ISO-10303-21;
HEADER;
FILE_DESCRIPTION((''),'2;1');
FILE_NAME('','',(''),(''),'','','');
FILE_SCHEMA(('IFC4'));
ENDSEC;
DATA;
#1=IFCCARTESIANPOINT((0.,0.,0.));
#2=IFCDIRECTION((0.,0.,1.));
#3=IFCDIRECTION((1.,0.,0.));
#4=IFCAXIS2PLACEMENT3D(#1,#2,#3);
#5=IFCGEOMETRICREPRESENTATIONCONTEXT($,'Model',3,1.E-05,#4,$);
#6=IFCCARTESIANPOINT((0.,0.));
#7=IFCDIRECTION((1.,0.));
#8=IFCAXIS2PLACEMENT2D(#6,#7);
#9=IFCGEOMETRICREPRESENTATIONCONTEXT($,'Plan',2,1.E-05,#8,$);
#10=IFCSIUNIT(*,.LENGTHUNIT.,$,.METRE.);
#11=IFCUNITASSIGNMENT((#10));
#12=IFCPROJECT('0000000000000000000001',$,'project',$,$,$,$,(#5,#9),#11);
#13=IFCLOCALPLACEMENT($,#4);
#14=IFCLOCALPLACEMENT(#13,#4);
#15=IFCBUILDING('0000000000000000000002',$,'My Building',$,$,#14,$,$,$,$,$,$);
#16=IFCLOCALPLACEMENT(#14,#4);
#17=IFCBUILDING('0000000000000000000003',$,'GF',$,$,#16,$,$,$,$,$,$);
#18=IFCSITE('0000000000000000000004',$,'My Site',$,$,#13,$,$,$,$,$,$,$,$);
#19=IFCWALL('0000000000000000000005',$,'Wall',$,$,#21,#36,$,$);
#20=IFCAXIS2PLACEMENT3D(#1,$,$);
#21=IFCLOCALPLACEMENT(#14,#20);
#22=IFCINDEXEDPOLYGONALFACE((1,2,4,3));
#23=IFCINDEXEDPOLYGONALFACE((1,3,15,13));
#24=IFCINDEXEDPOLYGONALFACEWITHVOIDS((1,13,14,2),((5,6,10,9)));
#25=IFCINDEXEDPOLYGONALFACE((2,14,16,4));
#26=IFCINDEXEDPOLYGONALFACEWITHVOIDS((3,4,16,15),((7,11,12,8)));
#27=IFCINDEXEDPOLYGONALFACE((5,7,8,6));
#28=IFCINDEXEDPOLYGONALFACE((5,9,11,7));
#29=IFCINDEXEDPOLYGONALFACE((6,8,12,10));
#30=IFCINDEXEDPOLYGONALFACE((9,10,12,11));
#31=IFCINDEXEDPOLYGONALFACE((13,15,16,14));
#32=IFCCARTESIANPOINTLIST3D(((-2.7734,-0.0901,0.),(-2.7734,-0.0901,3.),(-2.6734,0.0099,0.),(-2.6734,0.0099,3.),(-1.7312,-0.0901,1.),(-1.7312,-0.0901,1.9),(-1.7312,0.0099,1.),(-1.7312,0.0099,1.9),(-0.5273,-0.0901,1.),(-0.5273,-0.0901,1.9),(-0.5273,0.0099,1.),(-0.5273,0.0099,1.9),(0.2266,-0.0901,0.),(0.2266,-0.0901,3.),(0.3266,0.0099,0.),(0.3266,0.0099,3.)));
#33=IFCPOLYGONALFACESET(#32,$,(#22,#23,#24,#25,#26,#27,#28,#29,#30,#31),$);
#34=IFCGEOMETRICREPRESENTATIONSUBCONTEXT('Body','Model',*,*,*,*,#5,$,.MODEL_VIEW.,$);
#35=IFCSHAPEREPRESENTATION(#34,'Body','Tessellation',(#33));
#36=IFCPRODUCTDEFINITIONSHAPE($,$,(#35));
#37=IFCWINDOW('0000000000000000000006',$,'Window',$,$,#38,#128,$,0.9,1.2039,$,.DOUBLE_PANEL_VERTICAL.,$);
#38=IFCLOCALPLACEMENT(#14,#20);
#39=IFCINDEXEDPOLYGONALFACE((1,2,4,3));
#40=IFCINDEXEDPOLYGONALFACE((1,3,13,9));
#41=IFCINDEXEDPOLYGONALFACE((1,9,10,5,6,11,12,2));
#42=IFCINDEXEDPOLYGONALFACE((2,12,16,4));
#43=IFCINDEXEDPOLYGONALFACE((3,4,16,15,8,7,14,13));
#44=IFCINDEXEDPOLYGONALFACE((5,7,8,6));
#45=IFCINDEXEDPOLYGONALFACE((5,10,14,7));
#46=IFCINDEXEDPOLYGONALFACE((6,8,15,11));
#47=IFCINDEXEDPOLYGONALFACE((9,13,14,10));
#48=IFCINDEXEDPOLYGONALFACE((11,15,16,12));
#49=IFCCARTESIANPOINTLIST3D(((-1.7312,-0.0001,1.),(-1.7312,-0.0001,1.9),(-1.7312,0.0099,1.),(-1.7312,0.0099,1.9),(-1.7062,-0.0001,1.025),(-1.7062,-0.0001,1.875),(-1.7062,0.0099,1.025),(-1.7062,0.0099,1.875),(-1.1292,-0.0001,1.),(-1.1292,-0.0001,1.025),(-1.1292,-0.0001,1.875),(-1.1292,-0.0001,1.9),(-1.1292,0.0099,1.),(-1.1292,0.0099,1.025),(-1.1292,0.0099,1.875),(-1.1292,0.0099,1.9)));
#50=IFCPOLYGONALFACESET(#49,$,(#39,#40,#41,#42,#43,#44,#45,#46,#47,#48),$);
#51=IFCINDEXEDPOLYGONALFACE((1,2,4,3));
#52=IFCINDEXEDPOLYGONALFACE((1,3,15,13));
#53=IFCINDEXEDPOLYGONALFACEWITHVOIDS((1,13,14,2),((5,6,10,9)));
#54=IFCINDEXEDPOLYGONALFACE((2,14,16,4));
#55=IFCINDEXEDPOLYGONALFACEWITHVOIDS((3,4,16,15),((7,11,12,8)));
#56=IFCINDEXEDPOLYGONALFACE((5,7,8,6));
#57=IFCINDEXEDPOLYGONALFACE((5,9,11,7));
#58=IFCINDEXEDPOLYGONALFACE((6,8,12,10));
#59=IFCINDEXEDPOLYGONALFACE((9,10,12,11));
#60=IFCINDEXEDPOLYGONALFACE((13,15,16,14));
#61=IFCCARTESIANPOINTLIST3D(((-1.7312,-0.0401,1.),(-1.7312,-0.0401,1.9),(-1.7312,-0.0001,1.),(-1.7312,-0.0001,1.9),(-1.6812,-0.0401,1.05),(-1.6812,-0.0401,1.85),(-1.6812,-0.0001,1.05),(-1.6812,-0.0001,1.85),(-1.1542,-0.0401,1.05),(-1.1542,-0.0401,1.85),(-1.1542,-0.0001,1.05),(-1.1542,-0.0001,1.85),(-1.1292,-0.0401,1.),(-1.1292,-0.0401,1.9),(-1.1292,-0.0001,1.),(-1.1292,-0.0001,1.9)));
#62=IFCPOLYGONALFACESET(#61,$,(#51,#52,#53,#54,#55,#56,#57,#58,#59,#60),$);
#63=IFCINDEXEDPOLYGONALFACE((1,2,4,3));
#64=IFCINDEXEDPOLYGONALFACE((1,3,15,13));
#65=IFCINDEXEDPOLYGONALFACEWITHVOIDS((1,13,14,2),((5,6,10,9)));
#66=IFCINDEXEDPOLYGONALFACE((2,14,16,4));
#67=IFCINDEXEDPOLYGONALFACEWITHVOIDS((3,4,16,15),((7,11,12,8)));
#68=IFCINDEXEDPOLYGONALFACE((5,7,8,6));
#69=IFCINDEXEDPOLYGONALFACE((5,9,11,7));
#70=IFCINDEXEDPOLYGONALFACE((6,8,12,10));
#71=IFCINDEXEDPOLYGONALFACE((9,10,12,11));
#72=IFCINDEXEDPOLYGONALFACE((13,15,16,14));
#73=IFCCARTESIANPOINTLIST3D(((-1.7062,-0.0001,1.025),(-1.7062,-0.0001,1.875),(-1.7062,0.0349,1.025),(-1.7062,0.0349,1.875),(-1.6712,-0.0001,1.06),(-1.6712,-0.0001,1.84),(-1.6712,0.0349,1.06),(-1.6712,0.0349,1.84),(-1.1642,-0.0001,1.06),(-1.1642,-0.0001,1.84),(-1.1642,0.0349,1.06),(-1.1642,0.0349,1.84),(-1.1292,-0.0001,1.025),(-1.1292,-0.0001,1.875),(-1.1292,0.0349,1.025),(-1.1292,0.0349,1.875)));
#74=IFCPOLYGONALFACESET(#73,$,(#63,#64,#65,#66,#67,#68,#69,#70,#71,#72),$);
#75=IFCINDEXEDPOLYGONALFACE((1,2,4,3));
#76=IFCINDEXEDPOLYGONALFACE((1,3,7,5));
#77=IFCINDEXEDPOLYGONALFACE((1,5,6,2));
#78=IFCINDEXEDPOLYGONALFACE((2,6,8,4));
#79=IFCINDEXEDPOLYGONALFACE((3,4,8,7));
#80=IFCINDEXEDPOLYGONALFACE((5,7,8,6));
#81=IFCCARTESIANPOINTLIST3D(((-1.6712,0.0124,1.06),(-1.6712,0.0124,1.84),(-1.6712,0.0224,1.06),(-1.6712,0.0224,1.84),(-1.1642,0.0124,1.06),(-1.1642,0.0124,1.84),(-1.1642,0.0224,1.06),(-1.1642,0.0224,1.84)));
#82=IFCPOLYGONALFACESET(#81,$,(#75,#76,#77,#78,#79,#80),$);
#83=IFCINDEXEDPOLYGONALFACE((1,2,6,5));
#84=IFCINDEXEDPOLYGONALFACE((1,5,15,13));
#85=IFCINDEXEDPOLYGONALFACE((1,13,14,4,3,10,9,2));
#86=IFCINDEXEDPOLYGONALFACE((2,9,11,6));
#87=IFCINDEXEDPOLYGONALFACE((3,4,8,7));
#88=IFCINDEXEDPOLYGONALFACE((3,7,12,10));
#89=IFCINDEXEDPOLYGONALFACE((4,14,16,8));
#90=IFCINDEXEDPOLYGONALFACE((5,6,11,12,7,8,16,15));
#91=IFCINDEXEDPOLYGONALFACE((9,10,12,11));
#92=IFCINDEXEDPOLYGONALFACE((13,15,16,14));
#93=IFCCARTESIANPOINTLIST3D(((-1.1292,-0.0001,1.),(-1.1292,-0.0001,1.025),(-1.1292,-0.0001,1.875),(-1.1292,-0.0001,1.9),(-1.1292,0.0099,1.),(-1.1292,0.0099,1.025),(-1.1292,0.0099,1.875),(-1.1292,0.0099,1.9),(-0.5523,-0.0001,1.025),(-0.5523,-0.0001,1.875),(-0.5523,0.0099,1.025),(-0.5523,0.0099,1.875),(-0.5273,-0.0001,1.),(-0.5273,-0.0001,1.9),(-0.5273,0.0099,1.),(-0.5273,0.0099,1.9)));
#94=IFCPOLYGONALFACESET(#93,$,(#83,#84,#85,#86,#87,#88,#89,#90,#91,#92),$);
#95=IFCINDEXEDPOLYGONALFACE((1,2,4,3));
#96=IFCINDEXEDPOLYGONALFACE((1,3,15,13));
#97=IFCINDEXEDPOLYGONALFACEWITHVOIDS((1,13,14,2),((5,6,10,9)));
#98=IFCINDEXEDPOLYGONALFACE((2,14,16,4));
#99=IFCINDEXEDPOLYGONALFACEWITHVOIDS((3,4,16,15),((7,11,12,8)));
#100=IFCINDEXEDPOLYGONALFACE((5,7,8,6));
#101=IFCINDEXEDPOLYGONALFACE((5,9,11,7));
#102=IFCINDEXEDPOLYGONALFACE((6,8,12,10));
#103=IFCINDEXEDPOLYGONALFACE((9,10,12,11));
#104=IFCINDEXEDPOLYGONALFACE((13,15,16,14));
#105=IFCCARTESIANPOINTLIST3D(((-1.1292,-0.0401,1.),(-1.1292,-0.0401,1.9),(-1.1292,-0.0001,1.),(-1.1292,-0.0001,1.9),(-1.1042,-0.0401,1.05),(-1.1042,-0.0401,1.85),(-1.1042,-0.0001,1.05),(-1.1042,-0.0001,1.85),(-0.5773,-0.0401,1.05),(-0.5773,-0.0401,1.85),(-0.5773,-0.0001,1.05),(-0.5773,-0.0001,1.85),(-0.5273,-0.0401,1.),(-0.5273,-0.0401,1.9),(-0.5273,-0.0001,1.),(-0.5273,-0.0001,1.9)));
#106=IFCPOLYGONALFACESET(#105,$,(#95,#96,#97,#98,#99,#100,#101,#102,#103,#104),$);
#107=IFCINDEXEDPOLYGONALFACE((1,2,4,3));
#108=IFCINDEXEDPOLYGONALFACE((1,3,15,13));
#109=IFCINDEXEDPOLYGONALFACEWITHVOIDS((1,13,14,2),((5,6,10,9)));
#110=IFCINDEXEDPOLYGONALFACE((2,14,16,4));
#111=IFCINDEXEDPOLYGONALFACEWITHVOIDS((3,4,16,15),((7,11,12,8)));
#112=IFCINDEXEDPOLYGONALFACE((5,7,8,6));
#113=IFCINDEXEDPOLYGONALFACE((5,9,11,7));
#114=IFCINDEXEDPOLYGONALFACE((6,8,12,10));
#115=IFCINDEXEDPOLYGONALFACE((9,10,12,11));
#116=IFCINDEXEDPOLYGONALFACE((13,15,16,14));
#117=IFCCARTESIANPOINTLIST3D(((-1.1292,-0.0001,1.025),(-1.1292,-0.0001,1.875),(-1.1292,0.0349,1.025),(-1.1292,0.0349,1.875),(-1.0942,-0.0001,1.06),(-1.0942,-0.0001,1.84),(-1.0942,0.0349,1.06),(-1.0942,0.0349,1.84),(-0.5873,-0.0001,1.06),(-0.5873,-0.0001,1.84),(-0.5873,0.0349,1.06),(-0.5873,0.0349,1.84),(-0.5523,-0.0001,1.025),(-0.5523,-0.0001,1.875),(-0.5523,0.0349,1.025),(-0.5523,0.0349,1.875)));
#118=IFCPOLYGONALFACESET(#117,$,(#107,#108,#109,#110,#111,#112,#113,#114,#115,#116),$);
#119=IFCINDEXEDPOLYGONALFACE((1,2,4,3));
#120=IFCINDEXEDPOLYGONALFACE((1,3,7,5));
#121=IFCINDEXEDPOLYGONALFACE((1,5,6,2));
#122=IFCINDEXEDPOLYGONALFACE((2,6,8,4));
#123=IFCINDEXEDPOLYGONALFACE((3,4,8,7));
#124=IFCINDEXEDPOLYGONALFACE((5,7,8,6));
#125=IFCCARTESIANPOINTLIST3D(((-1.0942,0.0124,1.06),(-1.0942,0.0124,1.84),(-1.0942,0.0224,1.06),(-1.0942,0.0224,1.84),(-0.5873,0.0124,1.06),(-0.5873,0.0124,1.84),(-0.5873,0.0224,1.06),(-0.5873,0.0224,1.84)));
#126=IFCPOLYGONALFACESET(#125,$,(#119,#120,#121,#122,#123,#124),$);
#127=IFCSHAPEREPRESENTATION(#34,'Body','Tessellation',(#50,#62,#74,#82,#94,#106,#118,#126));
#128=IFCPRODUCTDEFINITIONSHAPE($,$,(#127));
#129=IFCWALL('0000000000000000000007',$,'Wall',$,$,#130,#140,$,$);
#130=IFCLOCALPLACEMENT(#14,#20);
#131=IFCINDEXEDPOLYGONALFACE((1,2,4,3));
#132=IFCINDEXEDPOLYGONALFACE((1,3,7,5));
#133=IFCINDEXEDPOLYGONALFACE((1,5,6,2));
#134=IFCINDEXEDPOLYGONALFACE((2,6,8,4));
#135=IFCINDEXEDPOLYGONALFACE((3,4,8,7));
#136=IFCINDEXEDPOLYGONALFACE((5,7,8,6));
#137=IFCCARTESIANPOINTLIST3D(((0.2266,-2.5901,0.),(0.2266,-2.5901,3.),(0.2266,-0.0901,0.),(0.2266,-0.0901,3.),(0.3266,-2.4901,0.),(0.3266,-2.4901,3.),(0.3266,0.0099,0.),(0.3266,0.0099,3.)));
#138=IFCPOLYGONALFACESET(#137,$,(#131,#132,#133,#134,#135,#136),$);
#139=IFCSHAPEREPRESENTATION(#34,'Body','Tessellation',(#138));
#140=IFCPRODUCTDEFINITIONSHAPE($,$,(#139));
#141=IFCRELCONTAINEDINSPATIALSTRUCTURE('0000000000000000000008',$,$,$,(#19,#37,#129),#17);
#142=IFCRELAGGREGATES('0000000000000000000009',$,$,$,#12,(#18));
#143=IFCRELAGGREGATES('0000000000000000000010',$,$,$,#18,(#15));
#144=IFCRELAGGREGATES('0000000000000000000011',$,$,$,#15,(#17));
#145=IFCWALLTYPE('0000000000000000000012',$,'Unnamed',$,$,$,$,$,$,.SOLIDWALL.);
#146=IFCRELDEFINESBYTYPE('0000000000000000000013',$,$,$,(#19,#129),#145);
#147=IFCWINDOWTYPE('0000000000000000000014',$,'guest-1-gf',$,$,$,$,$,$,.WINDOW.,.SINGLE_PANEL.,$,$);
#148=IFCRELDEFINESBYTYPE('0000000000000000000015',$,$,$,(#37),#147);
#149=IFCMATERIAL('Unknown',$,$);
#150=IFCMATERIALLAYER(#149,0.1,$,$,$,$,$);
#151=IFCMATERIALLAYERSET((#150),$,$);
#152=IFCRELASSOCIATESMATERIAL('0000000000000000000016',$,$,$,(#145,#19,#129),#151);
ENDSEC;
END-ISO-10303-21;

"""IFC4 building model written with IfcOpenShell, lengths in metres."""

from ifc_helpers import new_model, entity, si_unit, frame, origin_with_axes, origin_2d_with_axis, place, context, subcontext, project, spatial, line, indexed_curve, outline, extrude, shape, source, transform, mapped, material, layer, layer_set, layer_usage, type_object, type_shapes, element, fill, save


model = new_model("IFC4")

# Units and contexts
model_context = context("Model", 3, precision=1e-05, world=origin_with_axes())
plan_context = context("Plan", 2, precision=1e-05, world=origin_2d_with_axis())
body_context_1 = subcontext(model_context, "Body", "Model", "MODEL_VIEW")
body_context_2 = subcontext(plan_context, "Body", "Plan", "PLAN_VIEW")
ifc_project = project(units=[si_unit("LENGTHUNIT", "METRE")], contexts=[model_context, plan_context])

# Site, buildings
site_placement = place(None, origin_with_axes())
site = spatial("IfcSite", under=ifc_project, at=site_placement, Name="My Site")
building_1_placement = place(site_placement, origin_with_axes())
building_1 = spatial("IfcBuilding", under=site, at=building_1_placement, Name="My Building")
building_2_placement = place(building_1_placement, origin_with_axes())
building_2 = spatial("IfcBuilding", under=building_1, at=building_2_placement, Name="GF")

# Shared definitions
ifc_material = material(Name="Unknown")

# Shared definitions
ifc_layer_1 = layer(ifc_material, 0.1)
ifc_layer_set_1 = layer_set([ifc_layer_1])
wall_type = type_object("IfcWallType", Name="Unnamed", PredefinedType="SOLIDWALL", material=ifc_layer_set_1)

# Wall, opening, window
ifc_layer_usage_1 = layer_usage(ifc_layer_set_1, "AXIS2", "POSITIVE", 0.0)
wall_1_placement = place(building_2_placement, frame((-2.7734, -0.0901, 0.0), z_axis=(0.0, 0.0, 1.0), x_axis=(1.0, 0.0, 0.0)))
wall_1 = element("IfcWall", 1, at=wall_1_placement, inside=building_2, type_object=wall_type, material=ifc_layer_usage_1, Name="Wall", context=body_context_1, shape_type="SweptSolid", body=[
    extrude(outline(indexed_curve([(0.0, 0.0), (0.1, 0.1), (3.1, 0.1), (3.0, 0.0)], segments=[line(1, 2, 3, 4, 1)])), origin_with_axes(), (0.0, 0.0, 1.0), 3.0),
])
shared_shape_1 = source(origin_with_axes(), body_context_1, "Body", "SweptSolid", [
    extrude(outline(indexed_curve([(0.0, 0.0), (1.2039, 0.0), (1.2039, 0.9), (0.0, 0.9)], segments=[line(1, 2, 3, 4, 1)])), frame((0.0, -0.6, 0.0), z_axis=(0.0, -1.0, 0.0), x_axis=(1.0, 0.0, 0.0)), (0.0, 0.0, -1.0), 1.2),
])
opening_1_placement = place(wall_1_placement, frame((1.0422, 0.0, 1.0), z_axis=(0.0, 0.0, 1.0), x_axis=(1.0, 0.0, 0.0)))
opening_1 = element("IfcOpeningElement", 2, at=opening_1_placement, cuts=wall_1, PredefinedType="OPENING", context=body_context_1, shape_type="MappedRepresentation", body=[
    mapped(shared_shape_1, transform((0.0, 0.0, 0.0), x_axis=(1.0, 0.0, 0.0), y_axis=(0.0, 1.0, 0.0), z_axis=(0.0, 0.0, 1.0), scale=1.0)),
])
window_type_1 = type_object("IfcWindowType", Name="guest-1-gf", PartitioningType="SINGLE_PANEL", PredefinedType="WINDOW")
shared_shape_2 = source(origin_with_axes(), body_context_1, "Body", "SweptSolid", [
    extrude(outline(indexed_curve([(0.602, 0.0), (0.0, 0.0), (0.0, 0.9), (0.602, 0.9), (0.602, 0.875), (0.025, 0.875), (0.025, 0.025), (0.602, 0.025)], segments=[line(1, 2, 3, 4, 5, 6, 7, 8, 1)])), frame((0.0, 0.09, 0.0), z_axis=(0.0, -1.0, 0.0), x_axis=(1.0, 0.0, 0.0)), (0.0, 0.0, -1.0), 0.01),
    extrude(outline(indexed_curve([(0.0, 0.0), (0.602, 0.0), (0.602, 0.9), (0.0, 0.9)], segments=[line(1, 2, 3, 4, 1)]), holes=[indexed_curve([(0.05, 0.05), (0.577, 0.05), (0.577, 0.85), (0.05, 0.85)], segments=[line(1, 2, 3, 4, 1)])]), frame((0.0, 0.05, 0.0), z_axis=(0.0, -1.0, 0.0), x_axis=(1.0, 0.0, 0.0)), (0.0, 0.0, -1.0), 0.04),
    extrude(outline(indexed_curve([(0.0, 0.0), (0.577, 0.0), (0.577, 0.85), (0.0, 0.85)], segments=[line(1, 2, 3, 4, 1)]), holes=[indexed_curve([(0.035, 0.035), (0.542, 0.035), (0.542, 0.815), (0.035, 0.815)], segments=[line(1, 2, 3, 4, 1)])]), frame((0.025, 0.09, 0.025), z_axis=(0.0, -1.0, 0.0), x_axis=(1.0, 0.0, 0.0)), (0.0, 0.0, -1.0), 0.035),
    extrude(outline(indexed_curve([(0.035, 0.035), (0.542, 0.035), (0.542, 0.815), (0.035, 0.815)], segments=[line(1, 2, 3, 4, 1)])), frame((0.025, 0.1025, 0.025), z_axis=(0.0, -1.0, 0.0), x_axis=(1.0, 0.0, 0.0)), (0.0, 0.0, -1.0), 0.01),
    extrude(outline(indexed_curve([(0.0, 0.9), (0.6019, 0.9), (0.6019, 0.0), (0.0, 0.0), (0.0, 0.025), (0.5769, 0.025), (0.5769, 0.875), (0.0, 0.875)], segments=[line(1, 2, 3, 4, 5, 6, 7, 8, 1)])), frame((0.602, 0.09, 0.0), z_axis=(0.0, -1.0, 0.0), x_axis=(1.0, 0.0, 0.0)), (0.0, 0.0, -1.0), 0.01),
    extrude(outline(indexed_curve([(0.0, 0.0), (0.6019, 0.0), (0.6019, 0.9), (0.0, 0.9)], segments=[line(1, 2, 3, 4, 1)]), holes=[indexed_curve([(0.025, 0.05), (0.5519, 0.05), (0.5519, 0.85), (0.025, 0.85)], segments=[line(1, 2, 3, 4, 1)])]), frame((0.602, 0.05, 0.0), z_axis=(0.0, -1.0, 0.0), x_axis=(1.0, 0.0, 0.0)), (0.0, 0.0, -1.0), 0.04),
    extrude(outline(indexed_curve([(0.0, 0.0), (0.5769, 0.0), (0.5769, 0.85), (0.0, 0.85)], segments=[line(1, 2, 3, 4, 1)]), holes=[indexed_curve([(0.035, 0.035), (0.5419, 0.035), (0.5419, 0.815), (0.035, 0.815)], segments=[line(1, 2, 3, 4, 1)])]), frame((0.602, 0.09, 0.025), z_axis=(0.0, -1.0, 0.0), x_axis=(1.0, 0.0, 0.0)), (0.0, 0.0, -1.0), 0.035),
    extrude(outline(indexed_curve([(0.035, 0.035), (0.5419, 0.035), (0.5419, 0.815), (0.035, 0.815)], segments=[line(1, 2, 3, 4, 1)])), frame((0.602, 0.1025, 0.025), z_axis=(0.0, -1.0, 0.0), x_axis=(1.0, 0.0, 0.0)), (0.0, 0.0, -1.0), 0.01),
])
shared_shape_3 = source(origin_with_axes(), body_context_2, "Body", "Curve2D", [
    entity("IfcIndexedPolyCurve", entity("IfcCartesianPointList2D", [[0.05, 0.05], [0.577, 0.05]])),
    entity("IfcIndexedPolyCurve", entity("IfcCartesianPointList2D", [[0.0, 0.1], [0.025, 0.1], [0.025, 0.09], [0.05, 0.09], [0.05, 0.05], [0.0, 0.05]]), [entity("IfcLineIndex", [1, 2, 3, 4, 5, 6, 1])]),
    entity("IfcIndexedPolyCurve", entity("IfcCartesianPointList2D", [[0.602, 0.1], [0.602, 0.1], [0.602, 0.09], [0.577, 0.09], [0.577, 0.05], [0.602, 0.05]])),
    entity("IfcIndexedPolyCurve", entity("IfcCartesianPointList2D", [[0.025, 0.09], [0.06, 0.09], [0.06, 0.125], [0.025, 0.125]]), [entity("IfcLineIndex", [1, 2, 3, 4, 1])]),
    entity("IfcIndexedPolyCurve", entity("IfcCartesianPointList2D", [[0.602, 0.09], [0.567, 0.09], [0.567, 0.125], [0.602, 0.125]]), [entity("IfcLineIndex", [1, 2, 3, 4, 1])]),
    entity("IfcIndexedPolyCurve", entity("IfcCartesianPointList2D", [[0.06, 0.09], [0.567, 0.09]])),
    entity("IfcIndexedPolyCurve", entity("IfcCartesianPointList2D", [[0.06, 0.125], [0.567, 0.125]])),
    entity("IfcIndexedPolyCurve", entity("IfcCartesianPointList2D", [[0.06, 0.1075], [0.567, 0.1075]])),
    entity("IfcIndexedPolyCurve", entity("IfcCartesianPointList2D", [[0.627, 0.05], [1.1539, 0.05]])),
    entity("IfcIndexedPolyCurve", entity("IfcCartesianPointList2D", [[0.602, 0.1], [0.602, 0.1], [0.602, 0.09], [0.627, 0.09], [0.627, 0.05], [0.602, 0.05]])),
    entity("IfcIndexedPolyCurve", entity("IfcCartesianPointList2D", [[1.2039, 0.1], [1.1789, 0.1], [1.1789, 0.09], [1.1539, 0.09], [1.1539, 0.05], [1.2039, 0.05]]), [entity("IfcLineIndex", [1, 2, 3, 4, 5, 6, 1])]),
    entity("IfcIndexedPolyCurve", entity("IfcCartesianPointList2D", [[0.602, 0.09], [0.637, 0.09], [0.637, 0.125], [0.602, 0.125]]), [entity("IfcLineIndex", [1, 2, 3, 4, 1])]),
    entity("IfcIndexedPolyCurve", entity("IfcCartesianPointList2D", [[1.1789, 0.09], [1.1439, 0.09], [1.1439, 0.125], [1.1789, 0.125]]), [entity("IfcLineIndex", [1, 2, 3, 4, 1])]),
    entity("IfcIndexedPolyCurve", entity("IfcCartesianPointList2D", [[0.637, 0.09], [1.1439, 0.09]])),
    entity("IfcIndexedPolyCurve", entity("IfcCartesianPointList2D", [[0.637, 0.125], [1.1439, 0.125]])),
    entity("IfcIndexedPolyCurve", entity("IfcCartesianPointList2D", [[0.637, 0.1075], [1.1439, 0.1075]])),
])
type_shapes(window_type_1, [shared_shape_2, shared_shape_3])
window_1_placement = place(opening_1_placement, frame((0.0, 0.0, 0.0), z_axis=(0.0, 0.0, 1.0), x_axis=(1.0, 0.0, 0.0)))
window_1 = element("IfcWindow", 3, at=window_1_placement, inside=building_2, type_object=window_type_1, Name="Window", OverallHeight=0.9, OverallWidth=1.2039, PartitioningType="DOUBLE_PANEL_VERTICAL", shapes=[
    shape(body_context_1, "Body", "MappedRepresentation", [mapped(shared_shape_2, transform((0.0, 0.0, 0.0), x_axis=(1.0, 0.0, 0.0), y_axis=(0.0, 1.0, 0.0), z_axis=(0.0, 0.0, 1.0), scale=1.0))]),
    shape(body_context_2, "Body", "MappedRepresentation", [mapped(shared_shape_3, transform((0.0, 0.0, 0.0), x_axis=(1.0, 0.0, 0.0), y_axis=(0.0, 1.0, 0.0), z_axis=(0.0, 0.0, 1.0), scale=1.0))]),
])
fill(opening_1, window_1)

# Wall
ifc_layer_usage_2 = layer_usage(ifc_layer_set_1, "AXIS2", "POSITIVE", 0.0)
wall_2_placement = place(building_2_placement, frame((0.2266, -0.0901, 0.0), z_axis=(0.0, 0.0, 1.0), x_axis=(0.0, -1.0, 0.0)))
element("IfcWall", 4, at=wall_2_placement, inside=building_2, type_object=wall_type, material=ifc_layer_usage_2, Name="Wall", context=body_context_1, shape_type="SweptSolid", body=[
    extrude(outline(indexed_curve([(0.0, 0.0), (-0.1, 0.1), (2.4, 0.1), (2.5, 0.0)], segments=[line(1, 2, 3, 4, 1)])), origin_with_axes(), (0.0, 0.0, 1.0), 3.0),
])

save(model, "model.ifc")
